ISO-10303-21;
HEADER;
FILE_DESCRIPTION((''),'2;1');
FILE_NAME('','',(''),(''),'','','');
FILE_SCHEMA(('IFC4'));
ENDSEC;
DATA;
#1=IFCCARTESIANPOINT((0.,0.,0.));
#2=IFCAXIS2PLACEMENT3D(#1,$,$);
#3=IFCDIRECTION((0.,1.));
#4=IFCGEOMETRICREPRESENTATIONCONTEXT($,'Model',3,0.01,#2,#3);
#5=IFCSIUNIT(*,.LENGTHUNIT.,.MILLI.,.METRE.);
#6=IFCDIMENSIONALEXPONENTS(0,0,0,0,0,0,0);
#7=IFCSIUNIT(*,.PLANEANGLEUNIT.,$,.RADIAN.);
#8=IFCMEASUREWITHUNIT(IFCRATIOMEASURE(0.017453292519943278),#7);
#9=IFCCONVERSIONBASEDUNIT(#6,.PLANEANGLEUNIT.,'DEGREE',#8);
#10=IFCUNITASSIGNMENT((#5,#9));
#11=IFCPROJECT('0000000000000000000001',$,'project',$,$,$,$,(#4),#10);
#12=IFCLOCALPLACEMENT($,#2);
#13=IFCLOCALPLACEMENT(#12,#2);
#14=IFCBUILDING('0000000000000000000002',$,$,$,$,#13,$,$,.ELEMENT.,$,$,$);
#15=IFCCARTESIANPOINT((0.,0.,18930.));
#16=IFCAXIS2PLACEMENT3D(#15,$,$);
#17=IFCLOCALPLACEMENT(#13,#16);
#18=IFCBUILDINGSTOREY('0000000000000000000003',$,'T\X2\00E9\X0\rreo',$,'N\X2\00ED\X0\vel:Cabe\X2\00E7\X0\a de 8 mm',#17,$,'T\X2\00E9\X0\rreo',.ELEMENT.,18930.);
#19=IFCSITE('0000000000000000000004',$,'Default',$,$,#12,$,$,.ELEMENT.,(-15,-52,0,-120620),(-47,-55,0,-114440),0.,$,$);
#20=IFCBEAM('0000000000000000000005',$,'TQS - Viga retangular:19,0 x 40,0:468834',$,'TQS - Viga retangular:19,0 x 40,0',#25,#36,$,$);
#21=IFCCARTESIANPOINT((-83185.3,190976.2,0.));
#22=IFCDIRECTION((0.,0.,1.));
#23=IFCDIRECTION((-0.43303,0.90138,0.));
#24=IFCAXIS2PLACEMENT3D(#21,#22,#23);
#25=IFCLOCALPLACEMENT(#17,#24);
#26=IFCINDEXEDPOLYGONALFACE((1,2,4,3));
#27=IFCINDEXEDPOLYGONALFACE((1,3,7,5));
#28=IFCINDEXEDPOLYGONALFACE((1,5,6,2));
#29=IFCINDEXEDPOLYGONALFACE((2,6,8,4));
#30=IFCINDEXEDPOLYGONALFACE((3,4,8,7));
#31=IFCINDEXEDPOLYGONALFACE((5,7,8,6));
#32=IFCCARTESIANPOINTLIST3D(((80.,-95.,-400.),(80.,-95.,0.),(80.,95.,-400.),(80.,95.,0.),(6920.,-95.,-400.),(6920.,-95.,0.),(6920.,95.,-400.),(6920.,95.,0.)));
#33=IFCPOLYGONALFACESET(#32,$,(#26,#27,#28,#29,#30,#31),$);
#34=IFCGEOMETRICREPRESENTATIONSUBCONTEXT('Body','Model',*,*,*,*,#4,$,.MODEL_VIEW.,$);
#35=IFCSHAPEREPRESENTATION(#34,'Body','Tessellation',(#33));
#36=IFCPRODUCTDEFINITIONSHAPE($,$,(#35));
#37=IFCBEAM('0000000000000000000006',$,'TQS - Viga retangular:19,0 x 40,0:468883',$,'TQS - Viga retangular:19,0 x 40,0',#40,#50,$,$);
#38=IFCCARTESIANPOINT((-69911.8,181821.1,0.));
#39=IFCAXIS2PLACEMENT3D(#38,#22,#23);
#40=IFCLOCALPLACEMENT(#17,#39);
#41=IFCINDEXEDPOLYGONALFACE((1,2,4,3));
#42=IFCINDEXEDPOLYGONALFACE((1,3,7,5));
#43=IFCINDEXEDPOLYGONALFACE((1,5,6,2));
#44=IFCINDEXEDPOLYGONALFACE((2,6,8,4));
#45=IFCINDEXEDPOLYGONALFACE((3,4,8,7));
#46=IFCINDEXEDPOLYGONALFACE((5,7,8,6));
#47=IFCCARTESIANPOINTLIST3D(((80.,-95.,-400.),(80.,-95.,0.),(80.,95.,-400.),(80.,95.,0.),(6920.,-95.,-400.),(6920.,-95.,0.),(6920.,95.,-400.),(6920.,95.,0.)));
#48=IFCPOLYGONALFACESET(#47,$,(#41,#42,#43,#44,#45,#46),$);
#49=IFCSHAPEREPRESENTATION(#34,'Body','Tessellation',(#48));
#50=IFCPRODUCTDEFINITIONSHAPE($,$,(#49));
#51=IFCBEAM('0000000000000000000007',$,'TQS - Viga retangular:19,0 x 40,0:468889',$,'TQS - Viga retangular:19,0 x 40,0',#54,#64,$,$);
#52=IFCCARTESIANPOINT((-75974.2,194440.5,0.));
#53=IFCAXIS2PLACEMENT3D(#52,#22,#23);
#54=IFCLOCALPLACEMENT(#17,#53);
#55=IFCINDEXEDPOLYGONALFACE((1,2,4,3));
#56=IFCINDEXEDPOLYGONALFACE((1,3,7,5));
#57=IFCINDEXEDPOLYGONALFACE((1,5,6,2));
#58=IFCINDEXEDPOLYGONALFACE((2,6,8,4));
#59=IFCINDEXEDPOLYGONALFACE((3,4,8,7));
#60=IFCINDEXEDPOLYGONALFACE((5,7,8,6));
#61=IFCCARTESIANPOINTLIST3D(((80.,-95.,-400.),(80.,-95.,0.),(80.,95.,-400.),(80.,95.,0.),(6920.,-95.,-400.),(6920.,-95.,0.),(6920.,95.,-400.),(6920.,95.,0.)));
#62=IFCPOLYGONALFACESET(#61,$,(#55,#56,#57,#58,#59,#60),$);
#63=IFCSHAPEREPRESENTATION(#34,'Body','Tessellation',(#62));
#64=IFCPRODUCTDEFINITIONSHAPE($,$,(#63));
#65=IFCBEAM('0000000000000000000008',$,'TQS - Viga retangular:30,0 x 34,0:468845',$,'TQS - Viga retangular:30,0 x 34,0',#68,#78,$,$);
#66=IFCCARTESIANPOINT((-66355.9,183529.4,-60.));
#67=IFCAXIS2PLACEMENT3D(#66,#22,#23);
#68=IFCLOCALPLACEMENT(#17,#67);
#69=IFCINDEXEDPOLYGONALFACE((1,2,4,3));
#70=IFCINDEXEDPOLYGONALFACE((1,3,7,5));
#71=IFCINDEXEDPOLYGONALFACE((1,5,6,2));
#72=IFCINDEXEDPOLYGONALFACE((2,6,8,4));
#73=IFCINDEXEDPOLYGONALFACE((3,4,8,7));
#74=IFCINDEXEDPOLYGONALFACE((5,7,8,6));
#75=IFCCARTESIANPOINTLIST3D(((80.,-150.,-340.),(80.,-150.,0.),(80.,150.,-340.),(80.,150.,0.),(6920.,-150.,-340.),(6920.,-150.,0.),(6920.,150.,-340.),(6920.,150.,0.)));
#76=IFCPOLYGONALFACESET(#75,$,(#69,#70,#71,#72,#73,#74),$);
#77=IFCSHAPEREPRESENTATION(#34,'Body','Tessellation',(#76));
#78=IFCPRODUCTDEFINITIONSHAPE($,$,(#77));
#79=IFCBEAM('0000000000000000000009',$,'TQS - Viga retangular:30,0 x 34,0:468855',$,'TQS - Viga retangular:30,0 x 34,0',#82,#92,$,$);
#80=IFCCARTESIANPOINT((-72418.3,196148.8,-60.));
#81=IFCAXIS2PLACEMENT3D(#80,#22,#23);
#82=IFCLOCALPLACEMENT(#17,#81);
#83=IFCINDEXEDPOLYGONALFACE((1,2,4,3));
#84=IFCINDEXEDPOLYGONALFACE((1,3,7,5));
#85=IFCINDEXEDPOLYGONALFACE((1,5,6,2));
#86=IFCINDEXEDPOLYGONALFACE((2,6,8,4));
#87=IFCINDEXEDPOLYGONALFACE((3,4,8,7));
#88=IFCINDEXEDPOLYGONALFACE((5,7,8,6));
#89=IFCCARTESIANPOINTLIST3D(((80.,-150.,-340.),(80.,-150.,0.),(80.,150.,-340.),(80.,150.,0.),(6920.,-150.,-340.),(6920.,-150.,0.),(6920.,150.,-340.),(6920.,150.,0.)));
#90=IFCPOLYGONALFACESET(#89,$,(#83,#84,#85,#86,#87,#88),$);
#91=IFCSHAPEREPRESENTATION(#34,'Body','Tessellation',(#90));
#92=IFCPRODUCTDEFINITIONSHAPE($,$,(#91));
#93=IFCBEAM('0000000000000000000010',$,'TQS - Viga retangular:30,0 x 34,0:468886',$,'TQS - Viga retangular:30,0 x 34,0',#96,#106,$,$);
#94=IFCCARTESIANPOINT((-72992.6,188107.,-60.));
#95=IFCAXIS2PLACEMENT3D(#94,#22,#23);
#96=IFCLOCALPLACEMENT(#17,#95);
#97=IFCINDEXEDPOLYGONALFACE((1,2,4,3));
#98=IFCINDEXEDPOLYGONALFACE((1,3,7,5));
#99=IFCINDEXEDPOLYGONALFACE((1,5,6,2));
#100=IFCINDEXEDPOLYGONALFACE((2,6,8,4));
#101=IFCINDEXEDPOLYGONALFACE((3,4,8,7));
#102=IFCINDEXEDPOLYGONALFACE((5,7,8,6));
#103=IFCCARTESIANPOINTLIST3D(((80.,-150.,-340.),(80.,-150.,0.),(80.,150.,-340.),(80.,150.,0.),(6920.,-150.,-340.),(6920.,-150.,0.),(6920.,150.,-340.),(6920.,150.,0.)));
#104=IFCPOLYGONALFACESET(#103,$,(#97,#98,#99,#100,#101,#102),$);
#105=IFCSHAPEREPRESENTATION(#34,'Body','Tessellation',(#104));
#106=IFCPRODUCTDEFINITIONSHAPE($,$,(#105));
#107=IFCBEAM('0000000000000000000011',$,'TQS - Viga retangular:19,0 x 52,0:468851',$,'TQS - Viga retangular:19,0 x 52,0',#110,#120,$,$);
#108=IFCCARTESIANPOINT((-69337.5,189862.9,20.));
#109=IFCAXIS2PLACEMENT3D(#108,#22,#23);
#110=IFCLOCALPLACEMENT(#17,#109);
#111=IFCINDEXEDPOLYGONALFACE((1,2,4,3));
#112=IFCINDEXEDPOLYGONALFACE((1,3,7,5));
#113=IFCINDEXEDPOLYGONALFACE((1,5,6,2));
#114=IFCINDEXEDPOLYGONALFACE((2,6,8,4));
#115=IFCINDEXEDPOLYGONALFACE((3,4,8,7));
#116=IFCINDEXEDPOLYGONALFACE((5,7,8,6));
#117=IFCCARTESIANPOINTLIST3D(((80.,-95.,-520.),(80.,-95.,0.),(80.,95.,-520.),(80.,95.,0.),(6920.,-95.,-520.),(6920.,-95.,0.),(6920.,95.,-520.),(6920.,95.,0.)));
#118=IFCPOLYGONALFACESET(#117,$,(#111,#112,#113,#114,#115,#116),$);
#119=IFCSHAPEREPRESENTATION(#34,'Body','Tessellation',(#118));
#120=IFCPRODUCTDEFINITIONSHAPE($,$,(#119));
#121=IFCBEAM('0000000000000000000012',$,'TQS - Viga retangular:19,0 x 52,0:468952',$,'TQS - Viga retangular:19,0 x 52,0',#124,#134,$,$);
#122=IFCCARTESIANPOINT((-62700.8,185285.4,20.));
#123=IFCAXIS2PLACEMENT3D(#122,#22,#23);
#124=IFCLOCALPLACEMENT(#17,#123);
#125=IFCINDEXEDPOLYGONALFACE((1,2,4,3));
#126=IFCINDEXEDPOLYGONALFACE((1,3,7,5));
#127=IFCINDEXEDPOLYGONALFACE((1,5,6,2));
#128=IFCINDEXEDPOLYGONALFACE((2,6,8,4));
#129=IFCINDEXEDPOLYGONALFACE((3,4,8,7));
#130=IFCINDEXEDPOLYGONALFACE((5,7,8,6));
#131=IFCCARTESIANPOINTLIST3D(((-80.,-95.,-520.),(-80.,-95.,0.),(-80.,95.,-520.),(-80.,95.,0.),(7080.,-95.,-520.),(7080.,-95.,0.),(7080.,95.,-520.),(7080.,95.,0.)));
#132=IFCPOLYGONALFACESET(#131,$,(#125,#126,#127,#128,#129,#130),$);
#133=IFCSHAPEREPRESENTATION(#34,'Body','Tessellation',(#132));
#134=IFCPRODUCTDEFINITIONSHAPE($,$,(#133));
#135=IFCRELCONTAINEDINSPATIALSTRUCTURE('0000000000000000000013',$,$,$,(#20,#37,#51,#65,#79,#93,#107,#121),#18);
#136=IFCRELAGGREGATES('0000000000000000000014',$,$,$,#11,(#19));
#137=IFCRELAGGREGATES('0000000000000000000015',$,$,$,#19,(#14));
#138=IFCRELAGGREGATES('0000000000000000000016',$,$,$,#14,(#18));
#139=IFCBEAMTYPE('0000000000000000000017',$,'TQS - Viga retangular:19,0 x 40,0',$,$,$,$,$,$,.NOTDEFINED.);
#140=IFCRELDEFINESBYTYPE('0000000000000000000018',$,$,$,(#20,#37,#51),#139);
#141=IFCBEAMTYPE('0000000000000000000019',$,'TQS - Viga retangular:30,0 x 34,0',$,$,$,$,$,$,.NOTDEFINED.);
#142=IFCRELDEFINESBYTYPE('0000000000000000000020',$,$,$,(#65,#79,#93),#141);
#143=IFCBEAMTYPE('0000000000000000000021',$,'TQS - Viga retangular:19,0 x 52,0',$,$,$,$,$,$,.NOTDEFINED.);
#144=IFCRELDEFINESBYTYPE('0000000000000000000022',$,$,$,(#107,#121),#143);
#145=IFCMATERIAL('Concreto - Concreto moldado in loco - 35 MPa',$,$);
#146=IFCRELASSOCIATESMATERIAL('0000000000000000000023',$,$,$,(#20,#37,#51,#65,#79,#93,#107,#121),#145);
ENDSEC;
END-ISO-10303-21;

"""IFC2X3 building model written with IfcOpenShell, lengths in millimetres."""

from ifc_helpers import new_model, entity, si_unit, converted_unit, direction, frame, frame_2d, origin, place, context, subcontext, project, spatial, rectangle, extrude, material, type_object, element, save


model = new_model("IFC2X3")

# Units and contexts
model_context = context("Model", 3, precision=0.01, world=origin(), true_north=direction((0.0, 1.0)))
body_context = subcontext(model_context, "Body", "Model", "MODEL_VIEW")
ifc_project = project(units=[si_unit("LENGTHUNIT", "METRE", prefix="MILLI"), converted_unit("PLANEANGLEUNIT", "DEGREE", entity("IfcRatioMeasure", 0.017453292519943278), si_unit("PLANEANGLEUNIT", "RADIAN"), dimensions=[0, 0, 0, 0, 0, 0, 0])], contexts=[model_context])

# Site, building, storey
site_placement = place(None, origin())
site = spatial("IfcSite", under=ifc_project, at=site_placement, Name="Default", CompositionType="ELEMENT", RefLatitude=(-15, -52, 0, -120620), RefLongitude=(-47, -55, 0, -114440), RefElevation=0.0)
building_placement = place(site_placement, origin())
building = spatial("IfcBuilding", under=site, at=building_placement, CompositionType="ELEMENT")
storey_placement = place(building_placement, frame((0.0, 0.0, 18930.0)))
storey = spatial("IfcBuildingStorey", under=building, at=storey_placement, Name="Térreo", ObjectType="Nível:Cabeça de 8 mm", LongName="Térreo", CompositionType="ELEMENT", Elevation=18930.0)

# Beams
ifc_material_1 = material(Name="Concreto - Concreto moldado in loco - 35 MPa")
beam_type_1 = type_object("IfcBeamType", Name="TQS - Viga retangular:19,0 x 40,0", PredefinedType="NOTDEFINED")
beam_1_placement = place(storey_placement, frame((-83185.3, 190976.2, 0.0), z_axis=(0.0, 0.0, 1.0), x_axis=(-0.43303, 0.90138, 0.0)))
element("IfcBeam", 1, at=beam_1_placement, inside=storey, type_object=beam_type_1, material=ifc_material_1, Name="TQS - Viga retangular:19,0 x 40,0:468834", ObjectType="TQS - Viga retangular:19,0 x 40,0", context=body_context, shape_type="SweptSolid", body=[
    extrude(rectangle(XDim=400.0, YDim=190.0, at=frame_2d((0.0, 0.0), x_axis=(1.0, 0.0))), frame((80.0, 0.0, -200.0), z_axis=(1.0, 0.0, 0.0), x_axis=(0.0, 0.0, -1.0)), (0.0, 0.0, 1.0), 6840.0),
])
beam_2_placement = place(storey_placement, frame((-69911.8, 181821.1, 0.0), z_axis=(0.0, 0.0, 1.0), x_axis=(-0.43303, 0.90138, 0.0)))
element("IfcBeam", 2, at=beam_2_placement, inside=storey, type_object=beam_type_1, material=ifc_material_1, Name="TQS - Viga retangular:19,0 x 40,0:468883", ObjectType="TQS - Viga retangular:19,0 x 40,0", context=body_context, shape_type="SweptSolid", body=[
    extrude(rectangle(XDim=400.0, YDim=190.0, at=frame_2d((0.0, 0.0), x_axis=(1.0, 0.0))), frame((80.0, 0.0, -200.0), z_axis=(1.0, 0.0, 0.0), x_axis=(0.0, 0.0, -1.0)), (0.0, 0.0, 1.0), 6840.0),
])
beam_3_placement = place(storey_placement, frame((-75974.2, 194440.5, 0.0), z_axis=(0.0, 0.0, 1.0), x_axis=(-0.43303, 0.90138, 0.0)))
element("IfcBeam", 3, at=beam_3_placement, inside=storey, type_object=beam_type_1, material=ifc_material_1, Name="TQS - Viga retangular:19,0 x 40,0:468889", ObjectType="TQS - Viga retangular:19,0 x 40,0", context=body_context, shape_type="SweptSolid", body=[
    extrude(rectangle(XDim=400.0, YDim=190.0, at=frame_2d((0.0, 0.0), x_axis=(1.0, 0.0))), frame((80.0, 0.0, -200.0), z_axis=(1.0, 0.0, 0.0), x_axis=(0.0, 0.0, -1.0)), (0.0, 0.0, 1.0), 6840.0),
])
beam_type_2 = type_object("IfcBeamType", Name="TQS - Viga retangular:30,0 x 34,0", PredefinedType="NOTDEFINED")
beam_4_placement = place(storey_placement, frame((-66355.9, 183529.4, -60.0), z_axis=(0.0, 0.0, 1.0), x_axis=(-0.43303, 0.90138, 0.0)))
element("IfcBeam", 4, at=beam_4_placement, inside=storey, type_object=beam_type_2, material=ifc_material_1, Name="TQS - Viga retangular:30,0 x 34,0:468845", ObjectType="TQS - Viga retangular:30,0 x 34,0", context=body_context, shape_type="SweptSolid", body=[
    extrude(rectangle(XDim=340.0, YDim=300.0, at=frame_2d((0.0, 0.0), x_axis=(1.0, 0.0))), frame((80.0, 0.0, -170.0), z_axis=(1.0, 0.0, 0.0), x_axis=(0.0, 0.0, -1.0)), (0.0, 0.0, 1.0), 6840.0),
])
beam_5_placement = place(storey_placement, frame((-72418.3, 196148.8, -60.0), z_axis=(0.0, 0.0, 1.0), x_axis=(-0.43303, 0.90138, 0.0)))
element("IfcBeam", 5, at=beam_5_placement, inside=storey, type_object=beam_type_2, material=ifc_material_1, Name="TQS - Viga retangular:30,0 x 34,0:468855", ObjectType="TQS - Viga retangular:30,0 x 34,0", context=body_context, shape_type="SweptSolid", body=[
    extrude(rectangle(XDim=340.0, YDim=300.0, at=frame_2d((0.0, 0.0), x_axis=(1.0, 0.0))), frame((80.0, 0.0, -170.0), z_axis=(1.0, 0.0, 0.0), x_axis=(0.0, 0.0, -1.0)), (0.0, 0.0, 1.0), 6840.0),
])
beam_6_placement = place(storey_placement, frame((-72992.6, 188107.0, -60.0), z_axis=(0.0, 0.0, 1.0), x_axis=(-0.43303, 0.90138, 0.0)))
element("IfcBeam", 6, at=beam_6_placement, inside=storey, type_object=beam_type_2, material=ifc_material_1, Name="TQS - Viga retangular:30,0 x 34,0:468886", ObjectType="TQS - Viga retangular:30,0 x 34,0", context=body_context, shape_type="SweptSolid", body=[
    extrude(rectangle(XDim=340.0, YDim=300.0, at=frame_2d((0.0, 0.0), x_axis=(1.0, 0.0))), frame((80.0, 0.0, -170.0), z_axis=(1.0, 0.0, 0.0), x_axis=(0.0, 0.0, -1.0)), (0.0, 0.0, 1.0), 6840.0),
])
beam_type_3 = type_object("IfcBeamType", Name="TQS - Viga retangular:19,0 x 52,0", PredefinedType="NOTDEFINED")
beam_7_placement = place(storey_placement, frame((-69337.5, 189862.9, 20.0), z_axis=(0.0, 0.0, 1.0), x_axis=(-0.43303, 0.90138, 0.0)))
element("IfcBeam", 7, at=beam_7_placement, inside=storey, type_object=beam_type_3, material=ifc_material_1, Name="TQS - Viga retangular:19,0 x 52,0:468851", ObjectType="TQS - Viga retangular:19,0 x 52,0", context=body_context, shape_type="SweptSolid", body=[
    extrude(rectangle(XDim=520.0, YDim=190.0, at=frame_2d((0.0, 0.0), x_axis=(1.0, 0.0))), frame((80.0, 0.0, -260.0), z_axis=(1.0, 0.0, 0.0), x_axis=(0.0, 0.0, -1.0)), (0.0, 0.0, 1.0), 6840.0),
])
beam_8_placement = place(storey_placement, frame((-62700.8, 185285.4, 20.0), z_axis=(0.0, 0.0, 1.0), x_axis=(-0.43303, 0.90138, 0.0)))
element("IfcBeam", 8, at=beam_8_placement, inside=storey, type_object=beam_type_3, material=ifc_material_1, Name="TQS - Viga retangular:19,0 x 52,0:468952", ObjectType="TQS - Viga retangular:19,0 x 52,0", context=body_context, shape_type="SweptSolid", body=[
    extrude(rectangle(XDim=520.0, YDim=190.0, at=frame_2d((0.0, 0.0), x_axis=(1.0, 0.0))), frame((-80.0, 0.0, -260.0), z_axis=(1.0, 0.0, 0.0), x_axis=(0.0, 0.0, -1.0)), (0.0, 0.0, 1.0), 7160.0),
])

save(model, "model.ifc")
